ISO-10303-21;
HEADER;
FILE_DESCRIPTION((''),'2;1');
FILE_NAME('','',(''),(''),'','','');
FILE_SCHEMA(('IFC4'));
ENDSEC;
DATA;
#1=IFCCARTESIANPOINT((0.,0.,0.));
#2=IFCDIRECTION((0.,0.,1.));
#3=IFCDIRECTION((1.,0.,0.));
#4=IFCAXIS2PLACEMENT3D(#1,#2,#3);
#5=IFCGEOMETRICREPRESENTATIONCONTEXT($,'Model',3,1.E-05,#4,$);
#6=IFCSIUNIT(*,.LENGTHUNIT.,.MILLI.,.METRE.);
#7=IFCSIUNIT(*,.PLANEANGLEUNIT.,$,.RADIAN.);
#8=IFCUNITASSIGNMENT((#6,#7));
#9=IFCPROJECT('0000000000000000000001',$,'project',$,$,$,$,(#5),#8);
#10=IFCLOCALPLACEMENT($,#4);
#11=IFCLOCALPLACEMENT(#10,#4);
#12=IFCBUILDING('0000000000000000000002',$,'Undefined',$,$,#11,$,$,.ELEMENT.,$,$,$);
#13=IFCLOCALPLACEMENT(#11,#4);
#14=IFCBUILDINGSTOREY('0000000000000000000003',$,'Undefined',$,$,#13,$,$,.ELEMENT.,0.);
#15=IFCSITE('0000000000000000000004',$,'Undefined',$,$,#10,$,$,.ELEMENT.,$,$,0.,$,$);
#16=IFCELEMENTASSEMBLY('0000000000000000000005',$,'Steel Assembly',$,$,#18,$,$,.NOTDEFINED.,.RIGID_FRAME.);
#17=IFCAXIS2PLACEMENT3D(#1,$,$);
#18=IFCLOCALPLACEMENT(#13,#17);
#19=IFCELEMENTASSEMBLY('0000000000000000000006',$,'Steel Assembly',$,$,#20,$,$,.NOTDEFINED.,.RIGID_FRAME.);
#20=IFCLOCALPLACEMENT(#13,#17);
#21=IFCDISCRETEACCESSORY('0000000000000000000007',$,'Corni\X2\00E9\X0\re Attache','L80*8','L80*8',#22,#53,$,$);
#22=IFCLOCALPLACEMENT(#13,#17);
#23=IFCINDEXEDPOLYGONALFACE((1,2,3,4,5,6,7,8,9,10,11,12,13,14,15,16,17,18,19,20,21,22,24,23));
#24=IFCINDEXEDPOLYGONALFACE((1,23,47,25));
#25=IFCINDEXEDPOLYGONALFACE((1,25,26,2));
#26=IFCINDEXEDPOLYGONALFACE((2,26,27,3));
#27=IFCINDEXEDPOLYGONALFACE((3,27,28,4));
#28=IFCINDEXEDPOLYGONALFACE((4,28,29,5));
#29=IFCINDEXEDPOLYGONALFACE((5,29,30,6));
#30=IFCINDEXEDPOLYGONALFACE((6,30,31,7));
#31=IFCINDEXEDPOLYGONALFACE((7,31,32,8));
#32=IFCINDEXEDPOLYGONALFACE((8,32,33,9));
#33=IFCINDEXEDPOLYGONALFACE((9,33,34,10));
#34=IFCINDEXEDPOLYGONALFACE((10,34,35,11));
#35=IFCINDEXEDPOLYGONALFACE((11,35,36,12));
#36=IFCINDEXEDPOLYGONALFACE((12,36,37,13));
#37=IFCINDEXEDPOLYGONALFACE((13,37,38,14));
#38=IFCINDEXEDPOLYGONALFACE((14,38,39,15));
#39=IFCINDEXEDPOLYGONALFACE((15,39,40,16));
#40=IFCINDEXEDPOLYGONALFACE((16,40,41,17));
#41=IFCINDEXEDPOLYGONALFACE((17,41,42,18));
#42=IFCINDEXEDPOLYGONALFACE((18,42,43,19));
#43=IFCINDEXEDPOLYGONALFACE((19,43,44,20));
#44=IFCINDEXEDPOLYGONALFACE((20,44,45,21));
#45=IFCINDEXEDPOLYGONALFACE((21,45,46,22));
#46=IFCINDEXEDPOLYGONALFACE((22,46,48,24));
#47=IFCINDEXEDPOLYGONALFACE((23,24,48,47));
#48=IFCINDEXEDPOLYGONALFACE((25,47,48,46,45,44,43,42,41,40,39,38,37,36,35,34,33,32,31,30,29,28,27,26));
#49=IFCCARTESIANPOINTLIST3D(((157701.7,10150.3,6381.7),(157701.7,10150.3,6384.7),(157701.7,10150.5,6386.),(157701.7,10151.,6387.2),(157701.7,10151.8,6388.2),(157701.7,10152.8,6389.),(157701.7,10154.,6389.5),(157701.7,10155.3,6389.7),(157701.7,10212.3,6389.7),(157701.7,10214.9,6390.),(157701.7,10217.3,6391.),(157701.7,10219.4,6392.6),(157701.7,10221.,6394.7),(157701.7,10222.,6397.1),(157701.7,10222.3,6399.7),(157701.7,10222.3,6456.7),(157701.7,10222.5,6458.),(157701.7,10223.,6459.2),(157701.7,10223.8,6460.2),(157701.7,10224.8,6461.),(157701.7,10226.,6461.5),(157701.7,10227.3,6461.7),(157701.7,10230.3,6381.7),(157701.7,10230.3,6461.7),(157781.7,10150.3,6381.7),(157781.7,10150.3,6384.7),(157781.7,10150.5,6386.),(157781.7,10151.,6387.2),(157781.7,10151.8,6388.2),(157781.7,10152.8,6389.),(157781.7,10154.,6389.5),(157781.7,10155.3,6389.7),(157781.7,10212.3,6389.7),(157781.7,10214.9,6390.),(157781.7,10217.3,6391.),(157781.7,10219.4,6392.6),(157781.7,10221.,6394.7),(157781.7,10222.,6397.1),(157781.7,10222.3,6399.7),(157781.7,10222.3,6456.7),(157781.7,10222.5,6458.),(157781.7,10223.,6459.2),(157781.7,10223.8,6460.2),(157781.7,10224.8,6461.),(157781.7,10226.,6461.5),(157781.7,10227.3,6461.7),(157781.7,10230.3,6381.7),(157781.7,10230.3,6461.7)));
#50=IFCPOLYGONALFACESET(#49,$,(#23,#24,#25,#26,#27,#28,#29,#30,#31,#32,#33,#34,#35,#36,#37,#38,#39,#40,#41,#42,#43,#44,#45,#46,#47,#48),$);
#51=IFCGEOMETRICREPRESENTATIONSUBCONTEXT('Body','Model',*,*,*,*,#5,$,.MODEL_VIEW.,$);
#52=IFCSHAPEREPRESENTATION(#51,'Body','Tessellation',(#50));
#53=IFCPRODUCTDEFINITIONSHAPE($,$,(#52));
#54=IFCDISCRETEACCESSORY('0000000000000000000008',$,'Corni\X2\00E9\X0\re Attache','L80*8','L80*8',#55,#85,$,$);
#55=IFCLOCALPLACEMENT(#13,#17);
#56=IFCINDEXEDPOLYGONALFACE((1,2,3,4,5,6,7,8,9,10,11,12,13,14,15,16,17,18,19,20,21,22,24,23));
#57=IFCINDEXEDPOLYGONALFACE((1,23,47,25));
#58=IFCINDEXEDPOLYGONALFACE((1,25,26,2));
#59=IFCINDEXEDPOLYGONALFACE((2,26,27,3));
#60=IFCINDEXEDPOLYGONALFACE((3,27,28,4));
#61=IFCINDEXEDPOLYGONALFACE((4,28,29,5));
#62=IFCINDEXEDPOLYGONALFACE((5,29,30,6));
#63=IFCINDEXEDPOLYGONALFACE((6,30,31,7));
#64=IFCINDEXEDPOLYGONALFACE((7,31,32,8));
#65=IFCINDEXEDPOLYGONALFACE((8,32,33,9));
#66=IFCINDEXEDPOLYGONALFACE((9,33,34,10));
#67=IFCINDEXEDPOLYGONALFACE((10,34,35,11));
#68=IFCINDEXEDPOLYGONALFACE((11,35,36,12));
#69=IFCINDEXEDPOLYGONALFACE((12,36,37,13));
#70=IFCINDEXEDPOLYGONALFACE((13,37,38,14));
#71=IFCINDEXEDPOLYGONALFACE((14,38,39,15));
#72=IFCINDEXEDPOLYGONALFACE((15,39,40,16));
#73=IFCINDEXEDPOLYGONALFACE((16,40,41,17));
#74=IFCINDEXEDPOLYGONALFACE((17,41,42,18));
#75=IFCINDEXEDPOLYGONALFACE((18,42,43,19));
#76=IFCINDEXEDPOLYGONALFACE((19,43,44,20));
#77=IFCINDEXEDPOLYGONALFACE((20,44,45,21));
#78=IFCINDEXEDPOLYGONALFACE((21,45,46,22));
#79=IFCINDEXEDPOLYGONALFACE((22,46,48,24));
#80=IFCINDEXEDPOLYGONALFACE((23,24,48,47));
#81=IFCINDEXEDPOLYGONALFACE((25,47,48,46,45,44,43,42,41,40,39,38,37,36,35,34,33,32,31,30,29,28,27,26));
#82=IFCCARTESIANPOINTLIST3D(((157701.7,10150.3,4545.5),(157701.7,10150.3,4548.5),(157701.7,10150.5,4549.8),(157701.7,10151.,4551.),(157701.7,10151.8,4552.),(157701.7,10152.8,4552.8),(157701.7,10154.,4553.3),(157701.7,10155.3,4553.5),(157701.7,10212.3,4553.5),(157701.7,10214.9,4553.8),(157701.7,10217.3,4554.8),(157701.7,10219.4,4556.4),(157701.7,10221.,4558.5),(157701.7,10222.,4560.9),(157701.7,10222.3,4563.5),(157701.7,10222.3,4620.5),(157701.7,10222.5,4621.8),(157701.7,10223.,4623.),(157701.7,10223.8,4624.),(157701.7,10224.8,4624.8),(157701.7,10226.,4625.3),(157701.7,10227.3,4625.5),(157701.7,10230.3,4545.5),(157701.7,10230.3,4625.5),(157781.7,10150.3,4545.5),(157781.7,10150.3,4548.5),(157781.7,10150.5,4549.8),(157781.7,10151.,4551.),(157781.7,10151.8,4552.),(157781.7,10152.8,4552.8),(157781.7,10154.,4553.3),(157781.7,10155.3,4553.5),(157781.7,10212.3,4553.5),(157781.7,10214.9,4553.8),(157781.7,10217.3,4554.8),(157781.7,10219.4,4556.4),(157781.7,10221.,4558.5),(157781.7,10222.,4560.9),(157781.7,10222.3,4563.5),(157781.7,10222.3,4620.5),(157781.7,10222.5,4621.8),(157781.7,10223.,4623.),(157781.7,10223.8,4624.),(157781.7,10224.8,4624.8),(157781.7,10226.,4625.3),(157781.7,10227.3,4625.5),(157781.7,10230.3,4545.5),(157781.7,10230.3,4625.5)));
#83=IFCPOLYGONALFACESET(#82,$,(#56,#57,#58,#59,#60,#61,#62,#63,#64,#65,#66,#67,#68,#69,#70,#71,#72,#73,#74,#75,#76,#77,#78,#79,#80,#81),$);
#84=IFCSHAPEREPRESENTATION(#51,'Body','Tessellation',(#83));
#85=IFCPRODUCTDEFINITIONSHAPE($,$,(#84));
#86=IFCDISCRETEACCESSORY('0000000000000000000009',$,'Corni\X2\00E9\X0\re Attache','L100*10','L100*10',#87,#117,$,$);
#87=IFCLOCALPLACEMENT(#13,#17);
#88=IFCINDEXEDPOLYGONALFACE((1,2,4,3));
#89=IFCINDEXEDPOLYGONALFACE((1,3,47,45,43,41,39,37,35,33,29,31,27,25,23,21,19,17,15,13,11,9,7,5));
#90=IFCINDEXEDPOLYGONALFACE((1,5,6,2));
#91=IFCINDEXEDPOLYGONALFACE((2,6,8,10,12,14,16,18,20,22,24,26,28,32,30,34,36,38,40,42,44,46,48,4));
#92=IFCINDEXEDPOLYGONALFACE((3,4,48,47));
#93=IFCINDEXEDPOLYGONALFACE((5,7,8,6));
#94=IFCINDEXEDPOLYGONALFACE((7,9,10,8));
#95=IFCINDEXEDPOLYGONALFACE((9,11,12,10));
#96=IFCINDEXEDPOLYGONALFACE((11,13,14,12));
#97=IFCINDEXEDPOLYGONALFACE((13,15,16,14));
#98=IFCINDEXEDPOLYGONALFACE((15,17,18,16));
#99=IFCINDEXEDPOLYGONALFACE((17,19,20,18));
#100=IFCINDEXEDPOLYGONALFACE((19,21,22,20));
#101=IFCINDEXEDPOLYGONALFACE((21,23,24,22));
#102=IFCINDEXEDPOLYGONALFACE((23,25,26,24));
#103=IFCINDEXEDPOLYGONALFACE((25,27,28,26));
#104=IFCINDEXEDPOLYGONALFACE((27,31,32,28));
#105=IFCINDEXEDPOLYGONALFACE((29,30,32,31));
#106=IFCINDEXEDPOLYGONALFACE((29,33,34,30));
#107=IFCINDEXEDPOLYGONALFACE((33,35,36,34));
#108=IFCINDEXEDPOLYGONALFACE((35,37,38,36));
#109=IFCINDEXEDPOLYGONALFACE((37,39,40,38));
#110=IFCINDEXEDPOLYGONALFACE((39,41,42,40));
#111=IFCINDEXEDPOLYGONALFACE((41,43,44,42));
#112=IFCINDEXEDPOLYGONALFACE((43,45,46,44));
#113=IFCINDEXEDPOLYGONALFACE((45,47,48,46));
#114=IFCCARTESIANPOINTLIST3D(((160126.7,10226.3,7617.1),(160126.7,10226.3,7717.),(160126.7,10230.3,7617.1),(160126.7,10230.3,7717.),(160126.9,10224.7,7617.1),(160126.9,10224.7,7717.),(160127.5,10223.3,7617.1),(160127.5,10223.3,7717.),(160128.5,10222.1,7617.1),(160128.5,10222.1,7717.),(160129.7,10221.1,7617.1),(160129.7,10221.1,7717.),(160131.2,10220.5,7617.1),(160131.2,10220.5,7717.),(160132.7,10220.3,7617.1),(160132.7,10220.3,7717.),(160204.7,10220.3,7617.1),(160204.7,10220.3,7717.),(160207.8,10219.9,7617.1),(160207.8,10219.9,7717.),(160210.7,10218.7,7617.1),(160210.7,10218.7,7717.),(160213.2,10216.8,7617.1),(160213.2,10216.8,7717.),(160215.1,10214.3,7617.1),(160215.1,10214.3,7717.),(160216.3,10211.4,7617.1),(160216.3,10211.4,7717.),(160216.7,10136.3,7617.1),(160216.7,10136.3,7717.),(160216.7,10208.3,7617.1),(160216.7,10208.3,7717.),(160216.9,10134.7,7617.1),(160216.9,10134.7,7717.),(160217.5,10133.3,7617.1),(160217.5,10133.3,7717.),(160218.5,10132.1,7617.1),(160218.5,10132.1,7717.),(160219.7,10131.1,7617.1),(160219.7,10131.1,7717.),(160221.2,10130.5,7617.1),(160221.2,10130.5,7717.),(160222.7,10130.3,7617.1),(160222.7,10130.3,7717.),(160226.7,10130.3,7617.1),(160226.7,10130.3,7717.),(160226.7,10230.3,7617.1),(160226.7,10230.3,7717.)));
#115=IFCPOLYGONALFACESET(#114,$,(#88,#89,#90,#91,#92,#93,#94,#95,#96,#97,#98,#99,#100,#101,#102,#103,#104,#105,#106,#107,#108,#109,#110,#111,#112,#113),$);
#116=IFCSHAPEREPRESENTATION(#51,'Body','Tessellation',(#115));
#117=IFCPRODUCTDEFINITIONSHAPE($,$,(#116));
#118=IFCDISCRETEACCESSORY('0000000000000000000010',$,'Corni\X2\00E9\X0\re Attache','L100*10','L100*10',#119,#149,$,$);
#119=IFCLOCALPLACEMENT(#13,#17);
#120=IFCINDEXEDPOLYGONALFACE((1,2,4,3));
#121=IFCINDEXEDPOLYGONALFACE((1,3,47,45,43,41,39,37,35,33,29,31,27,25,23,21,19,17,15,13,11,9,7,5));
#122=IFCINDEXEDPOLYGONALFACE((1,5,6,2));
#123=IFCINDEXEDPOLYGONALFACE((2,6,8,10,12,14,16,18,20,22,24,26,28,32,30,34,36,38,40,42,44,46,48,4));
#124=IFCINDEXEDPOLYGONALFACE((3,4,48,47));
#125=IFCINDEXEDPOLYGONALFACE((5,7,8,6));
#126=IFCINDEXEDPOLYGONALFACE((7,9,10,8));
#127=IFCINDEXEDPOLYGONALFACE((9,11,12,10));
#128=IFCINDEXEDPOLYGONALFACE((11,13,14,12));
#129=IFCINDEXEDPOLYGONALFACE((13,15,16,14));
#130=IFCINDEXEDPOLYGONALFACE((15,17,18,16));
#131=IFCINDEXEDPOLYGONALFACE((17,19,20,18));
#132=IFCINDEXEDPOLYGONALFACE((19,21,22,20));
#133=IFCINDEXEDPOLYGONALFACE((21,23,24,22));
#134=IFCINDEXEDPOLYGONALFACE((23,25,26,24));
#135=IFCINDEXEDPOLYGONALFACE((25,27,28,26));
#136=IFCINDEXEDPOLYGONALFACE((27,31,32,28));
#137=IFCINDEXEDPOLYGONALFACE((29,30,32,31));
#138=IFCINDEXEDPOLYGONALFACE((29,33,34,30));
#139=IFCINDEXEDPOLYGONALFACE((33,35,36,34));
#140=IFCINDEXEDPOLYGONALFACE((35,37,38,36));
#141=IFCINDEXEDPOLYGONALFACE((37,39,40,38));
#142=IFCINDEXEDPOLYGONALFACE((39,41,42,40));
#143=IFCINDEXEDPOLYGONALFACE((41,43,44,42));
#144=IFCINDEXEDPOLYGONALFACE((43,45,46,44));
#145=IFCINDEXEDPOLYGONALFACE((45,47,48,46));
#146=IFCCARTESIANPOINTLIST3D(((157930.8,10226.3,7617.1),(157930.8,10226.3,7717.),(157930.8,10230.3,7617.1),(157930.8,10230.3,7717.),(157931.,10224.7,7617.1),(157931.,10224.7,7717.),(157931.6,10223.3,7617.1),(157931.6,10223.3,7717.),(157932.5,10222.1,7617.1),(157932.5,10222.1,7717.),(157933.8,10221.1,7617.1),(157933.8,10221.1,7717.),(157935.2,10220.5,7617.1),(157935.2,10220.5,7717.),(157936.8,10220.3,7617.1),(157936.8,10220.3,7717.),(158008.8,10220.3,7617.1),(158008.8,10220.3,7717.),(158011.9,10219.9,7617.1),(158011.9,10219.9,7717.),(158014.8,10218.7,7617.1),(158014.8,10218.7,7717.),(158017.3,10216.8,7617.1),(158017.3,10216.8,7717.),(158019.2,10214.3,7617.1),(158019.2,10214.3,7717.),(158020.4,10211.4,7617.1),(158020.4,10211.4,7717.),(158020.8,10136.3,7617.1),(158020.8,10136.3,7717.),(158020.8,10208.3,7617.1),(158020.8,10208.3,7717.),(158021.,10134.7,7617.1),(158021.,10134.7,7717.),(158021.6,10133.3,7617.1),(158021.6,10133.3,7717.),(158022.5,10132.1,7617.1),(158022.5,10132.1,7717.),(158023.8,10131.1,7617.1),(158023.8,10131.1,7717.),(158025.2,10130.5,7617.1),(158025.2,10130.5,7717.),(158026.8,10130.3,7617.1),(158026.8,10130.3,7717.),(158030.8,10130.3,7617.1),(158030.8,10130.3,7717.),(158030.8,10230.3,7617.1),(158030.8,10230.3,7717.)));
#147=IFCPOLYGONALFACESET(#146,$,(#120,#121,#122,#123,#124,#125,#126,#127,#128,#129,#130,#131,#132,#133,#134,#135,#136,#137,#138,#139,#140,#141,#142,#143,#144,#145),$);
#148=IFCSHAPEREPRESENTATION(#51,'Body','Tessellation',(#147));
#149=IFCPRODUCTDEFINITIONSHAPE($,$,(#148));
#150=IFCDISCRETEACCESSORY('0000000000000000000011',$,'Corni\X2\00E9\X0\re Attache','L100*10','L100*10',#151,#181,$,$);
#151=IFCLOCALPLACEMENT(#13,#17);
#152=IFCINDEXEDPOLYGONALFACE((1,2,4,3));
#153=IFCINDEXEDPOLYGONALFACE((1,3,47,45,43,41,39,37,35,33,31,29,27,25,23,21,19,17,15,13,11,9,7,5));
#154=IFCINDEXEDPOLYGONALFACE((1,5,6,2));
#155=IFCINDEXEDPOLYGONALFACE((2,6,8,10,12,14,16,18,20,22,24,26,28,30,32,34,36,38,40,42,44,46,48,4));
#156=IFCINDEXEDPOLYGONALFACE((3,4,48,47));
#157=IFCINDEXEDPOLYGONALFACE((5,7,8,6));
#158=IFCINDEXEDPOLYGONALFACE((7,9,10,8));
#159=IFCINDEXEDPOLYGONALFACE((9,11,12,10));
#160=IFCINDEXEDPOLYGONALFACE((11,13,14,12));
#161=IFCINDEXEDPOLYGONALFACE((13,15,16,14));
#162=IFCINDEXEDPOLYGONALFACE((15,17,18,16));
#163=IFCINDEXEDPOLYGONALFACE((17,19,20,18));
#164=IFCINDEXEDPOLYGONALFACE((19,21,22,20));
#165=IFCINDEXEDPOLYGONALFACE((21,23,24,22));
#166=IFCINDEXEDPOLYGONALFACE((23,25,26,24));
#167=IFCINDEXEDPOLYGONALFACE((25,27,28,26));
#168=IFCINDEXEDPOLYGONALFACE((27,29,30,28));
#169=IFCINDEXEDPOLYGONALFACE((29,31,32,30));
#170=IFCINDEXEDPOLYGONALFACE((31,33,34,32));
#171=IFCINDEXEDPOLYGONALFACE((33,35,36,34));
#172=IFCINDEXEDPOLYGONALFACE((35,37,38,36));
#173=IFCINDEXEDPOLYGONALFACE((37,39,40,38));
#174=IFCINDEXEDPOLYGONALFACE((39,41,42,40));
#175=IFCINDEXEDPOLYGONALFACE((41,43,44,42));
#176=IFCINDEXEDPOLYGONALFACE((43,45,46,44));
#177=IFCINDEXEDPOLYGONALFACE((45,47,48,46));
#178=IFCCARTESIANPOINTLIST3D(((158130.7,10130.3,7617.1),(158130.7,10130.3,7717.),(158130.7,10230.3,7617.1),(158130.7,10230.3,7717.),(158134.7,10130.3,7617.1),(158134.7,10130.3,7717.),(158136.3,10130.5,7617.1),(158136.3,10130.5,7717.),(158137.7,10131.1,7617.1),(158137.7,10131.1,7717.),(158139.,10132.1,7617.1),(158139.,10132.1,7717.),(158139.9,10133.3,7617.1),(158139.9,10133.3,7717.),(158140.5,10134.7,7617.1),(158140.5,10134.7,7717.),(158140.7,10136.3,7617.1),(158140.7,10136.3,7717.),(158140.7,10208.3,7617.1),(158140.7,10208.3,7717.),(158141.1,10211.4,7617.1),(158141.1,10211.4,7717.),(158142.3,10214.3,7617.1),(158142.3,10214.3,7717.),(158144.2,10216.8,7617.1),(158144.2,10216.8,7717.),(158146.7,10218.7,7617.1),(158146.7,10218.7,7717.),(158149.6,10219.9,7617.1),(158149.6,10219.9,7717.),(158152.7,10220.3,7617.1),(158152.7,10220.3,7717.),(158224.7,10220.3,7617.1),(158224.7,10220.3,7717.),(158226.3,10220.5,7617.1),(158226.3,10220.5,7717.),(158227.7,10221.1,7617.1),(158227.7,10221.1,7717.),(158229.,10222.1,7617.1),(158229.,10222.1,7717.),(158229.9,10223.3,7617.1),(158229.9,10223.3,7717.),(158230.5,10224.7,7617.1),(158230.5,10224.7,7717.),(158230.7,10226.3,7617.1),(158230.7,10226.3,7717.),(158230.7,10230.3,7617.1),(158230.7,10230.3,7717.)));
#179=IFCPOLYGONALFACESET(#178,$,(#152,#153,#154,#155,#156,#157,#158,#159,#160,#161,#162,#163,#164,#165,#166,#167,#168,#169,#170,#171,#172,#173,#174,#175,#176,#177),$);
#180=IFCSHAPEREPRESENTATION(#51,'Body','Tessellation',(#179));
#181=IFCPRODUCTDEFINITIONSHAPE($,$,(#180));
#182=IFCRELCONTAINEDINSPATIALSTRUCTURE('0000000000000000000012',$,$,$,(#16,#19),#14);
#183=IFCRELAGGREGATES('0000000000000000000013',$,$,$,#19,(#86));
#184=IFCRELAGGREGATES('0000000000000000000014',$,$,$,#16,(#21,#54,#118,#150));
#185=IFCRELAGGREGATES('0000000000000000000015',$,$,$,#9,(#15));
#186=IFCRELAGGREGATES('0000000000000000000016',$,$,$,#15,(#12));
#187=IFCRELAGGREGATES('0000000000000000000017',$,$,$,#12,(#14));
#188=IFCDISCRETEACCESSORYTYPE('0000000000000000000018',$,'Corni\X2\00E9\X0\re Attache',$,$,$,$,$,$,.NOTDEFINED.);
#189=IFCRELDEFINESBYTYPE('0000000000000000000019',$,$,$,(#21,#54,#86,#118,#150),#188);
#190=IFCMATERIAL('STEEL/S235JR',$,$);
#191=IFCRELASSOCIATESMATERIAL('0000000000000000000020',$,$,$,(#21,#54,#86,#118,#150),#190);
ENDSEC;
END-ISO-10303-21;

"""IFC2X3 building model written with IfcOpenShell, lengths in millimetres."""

from ifc_helpers import new_model, si_unit, frame, origin_with_axes, origin_2d_with_axis, place, context, subcontext, project, spatial, l_section, extrude, material, type_object, element, aggregate, save


model = new_model("IFC2X3")

# Units and contexts
model_context = context("Model", 3, precision=1e-05, world=origin_with_axes())
body_context = subcontext(model_context, "Body", "Model", "MODEL_VIEW")
ifc_project = project(units=[si_unit("LENGTHUNIT", "METRE", prefix="MILLI"), si_unit("PLANEANGLEUNIT", "RADIAN")], contexts=[model_context])

# Site, building, storey
site_placement = place(None, origin_with_axes())
site = spatial("IfcSite", under=ifc_project, at=site_placement, Name="Undefined", CompositionType="ELEMENT", RefElevation=0.0)
building_placement = place(site_placement, origin_with_axes())
building = spatial("IfcBuilding", under=site, at=building_placement, Name="Undefined", CompositionType="ELEMENT")
storey_placement = place(building_placement, origin_with_axes())
storey = spatial("IfcBuildingStorey", under=building, at=storey_placement, Name="Undefined", CompositionType="ELEMENT", Elevation=0.0)

# Element assembly
assembly_1_placement = place(storey_placement, origin_with_axes())
assembly_1 = element("IfcElementAssembly", 1, at=assembly_1_placement, inside=storey, Name="Steel Assembly", AssemblyPlace="NOTDEFINED", PredefinedType="RIGID_FRAME")
ifc_material_1 = material(Name="STEEL/S235JR")

# Element assembly
assembly_2_placement = place(storey_placement, origin_with_axes())
assembly_2 = element("IfcElementAssembly", 2, at=assembly_2_placement, inside=storey, Name="Steel Assembly", AssemblyPlace="NOTDEFINED", PredefinedType="RIGID_FRAME")

# Discrete accessories
discrete_accessory_type_1 = type_object("IfcDiscreteAccessoryType", Name="Corniére Attache")
discrete_accessory_1_placement = place(assembly_1_placement, frame((157781.7, 10190.3, 6421.7), z_axis=(0.0, -1.0, 0.0), x_axis=(-1.0, 0.0, 0.0)))
discrete_accessory_1 = element("IfcDiscreteAccessory", 3, at=discrete_accessory_1_placement, type_object=discrete_accessory_type_1, material=ifc_material_1, Name="Corniére Attache", Description="L80*8", ObjectType="L80*8", context=body_context, shape_type="SweptSolid", body=[
    extrude(l_section(Depth=80.0, Width=80.0, Thickness=8.0, FilletRadius=10.0, EdgeRadius=5.0, at=origin_2d_with_axis()), frame((80.0, 0.0, 0.0), z_axis=(-1.0, 0.0, 0.0), x_axis=(0.0, -1.0, 0.0)), (0.0, 0.0, 1.0), 80.0),
])
discrete_accessory_2_placement = place(assembly_1_placement, frame((157781.7, 10190.3, 4585.5), z_axis=(0.0, -1.0, 0.0), x_axis=(-1.0, 0.0, 0.0)))
discrete_accessory_2 = element("IfcDiscreteAccessory", 4, at=discrete_accessory_2_placement, type_object=discrete_accessory_type_1, material=ifc_material_1, Name="Corniére Attache", Description="L80*8", ObjectType="L80*8", context=body_context, shape_type="SweptSolid", body=[
    extrude(l_section(Depth=80.0, Width=80.0, Thickness=8.0, FilletRadius=10.0, EdgeRadius=5.0, at=origin_2d_with_axis()), frame((80.0, 0.0, 0.0), z_axis=(-1.0, 0.0, 0.0), x_axis=(0.0, -1.0, 0.0)), (0.0, 0.0, 1.0), 80.0),
])
discrete_accessory_3_placement = place(assembly_2_placement, frame((160176.7, 10180.3, 7717.0), z_axis=(0.0, -1.0, 0.0), x_axis=(0.0, 0.0, -1.0)))
discrete_accessory_3 = element("IfcDiscreteAccessory", 5, at=discrete_accessory_3_placement, type_object=discrete_accessory_type_1, material=ifc_material_1, Name="Corniére Attache", Description="L100*10", ObjectType="L100*10", context=body_context, shape_type="SweptSolid", body=[
    extrude(l_section(Depth=100.0, Width=100.0, Thickness=10.0, FilletRadius=12.0, EdgeRadius=6.0, at=origin_2d_with_axis()), frame((99.9, 0.0, 0.0), z_axis=(-1.0, 0.0, 0.0), x_axis=(0.0, -1.0, 0.0)), (0.0, 0.0, 1.0), 99.9),
])
discrete_accessory_4_placement = place(assembly_1_placement, frame((157980.8, 10180.3, 7717.0), z_axis=(0.0, -1.0, 0.0), x_axis=(0.0, 0.0, -1.0)))
discrete_accessory_4 = element("IfcDiscreteAccessory", 6, at=discrete_accessory_4_placement, type_object=discrete_accessory_type_1, material=ifc_material_1, Name="Corniére Attache", Description="L100*10", ObjectType="L100*10", context=body_context, shape_type="SweptSolid", body=[
    extrude(l_section(Depth=100.0, Width=100.0, Thickness=10.0, FilletRadius=12.0, EdgeRadius=6.0, at=origin_2d_with_axis()), frame((99.9, 0.0, 0.0), z_axis=(-1.0, 0.0, 0.0), x_axis=(0.0, -1.0, 0.0)), (0.0, 0.0, 1.0), 99.9),
])
discrete_accessory_5_placement = place(assembly_1_placement, frame((158180.7, 10180.3, 7617.1), z_axis=(0.0, 0.0, 1.0), x_axis=(1.0, 0.0, 0.0)))
discrete_accessory_5 = element("IfcDiscreteAccessory", 7, at=discrete_accessory_5_placement, type_object=discrete_accessory_type_1, material=ifc_material_1, Name="Corniére Attache", Description="L100*10", ObjectType="L100*10", context=body_context, shape_type="SweptSolid", body=[
    extrude(l_section(Depth=100.0, Width=100.0, Thickness=10.0, FilletRadius=12.0, EdgeRadius=6.0, at=origin_2d_with_axis()), frame((0.0, 0.0, 99.9), z_axis=(0.0, 0.0, -1.0), x_axis=(1.0, 0.0, 0.0)), (0.0, 0.0, 1.0), 99.9),
])
aggregate(assembly_2, [discrete_accessory_3])

aggregate(assembly_1, [discrete_accessory_1, discrete_accessory_2, discrete_accessory_4, discrete_accessory_5])

save(model, "model.ifc")
